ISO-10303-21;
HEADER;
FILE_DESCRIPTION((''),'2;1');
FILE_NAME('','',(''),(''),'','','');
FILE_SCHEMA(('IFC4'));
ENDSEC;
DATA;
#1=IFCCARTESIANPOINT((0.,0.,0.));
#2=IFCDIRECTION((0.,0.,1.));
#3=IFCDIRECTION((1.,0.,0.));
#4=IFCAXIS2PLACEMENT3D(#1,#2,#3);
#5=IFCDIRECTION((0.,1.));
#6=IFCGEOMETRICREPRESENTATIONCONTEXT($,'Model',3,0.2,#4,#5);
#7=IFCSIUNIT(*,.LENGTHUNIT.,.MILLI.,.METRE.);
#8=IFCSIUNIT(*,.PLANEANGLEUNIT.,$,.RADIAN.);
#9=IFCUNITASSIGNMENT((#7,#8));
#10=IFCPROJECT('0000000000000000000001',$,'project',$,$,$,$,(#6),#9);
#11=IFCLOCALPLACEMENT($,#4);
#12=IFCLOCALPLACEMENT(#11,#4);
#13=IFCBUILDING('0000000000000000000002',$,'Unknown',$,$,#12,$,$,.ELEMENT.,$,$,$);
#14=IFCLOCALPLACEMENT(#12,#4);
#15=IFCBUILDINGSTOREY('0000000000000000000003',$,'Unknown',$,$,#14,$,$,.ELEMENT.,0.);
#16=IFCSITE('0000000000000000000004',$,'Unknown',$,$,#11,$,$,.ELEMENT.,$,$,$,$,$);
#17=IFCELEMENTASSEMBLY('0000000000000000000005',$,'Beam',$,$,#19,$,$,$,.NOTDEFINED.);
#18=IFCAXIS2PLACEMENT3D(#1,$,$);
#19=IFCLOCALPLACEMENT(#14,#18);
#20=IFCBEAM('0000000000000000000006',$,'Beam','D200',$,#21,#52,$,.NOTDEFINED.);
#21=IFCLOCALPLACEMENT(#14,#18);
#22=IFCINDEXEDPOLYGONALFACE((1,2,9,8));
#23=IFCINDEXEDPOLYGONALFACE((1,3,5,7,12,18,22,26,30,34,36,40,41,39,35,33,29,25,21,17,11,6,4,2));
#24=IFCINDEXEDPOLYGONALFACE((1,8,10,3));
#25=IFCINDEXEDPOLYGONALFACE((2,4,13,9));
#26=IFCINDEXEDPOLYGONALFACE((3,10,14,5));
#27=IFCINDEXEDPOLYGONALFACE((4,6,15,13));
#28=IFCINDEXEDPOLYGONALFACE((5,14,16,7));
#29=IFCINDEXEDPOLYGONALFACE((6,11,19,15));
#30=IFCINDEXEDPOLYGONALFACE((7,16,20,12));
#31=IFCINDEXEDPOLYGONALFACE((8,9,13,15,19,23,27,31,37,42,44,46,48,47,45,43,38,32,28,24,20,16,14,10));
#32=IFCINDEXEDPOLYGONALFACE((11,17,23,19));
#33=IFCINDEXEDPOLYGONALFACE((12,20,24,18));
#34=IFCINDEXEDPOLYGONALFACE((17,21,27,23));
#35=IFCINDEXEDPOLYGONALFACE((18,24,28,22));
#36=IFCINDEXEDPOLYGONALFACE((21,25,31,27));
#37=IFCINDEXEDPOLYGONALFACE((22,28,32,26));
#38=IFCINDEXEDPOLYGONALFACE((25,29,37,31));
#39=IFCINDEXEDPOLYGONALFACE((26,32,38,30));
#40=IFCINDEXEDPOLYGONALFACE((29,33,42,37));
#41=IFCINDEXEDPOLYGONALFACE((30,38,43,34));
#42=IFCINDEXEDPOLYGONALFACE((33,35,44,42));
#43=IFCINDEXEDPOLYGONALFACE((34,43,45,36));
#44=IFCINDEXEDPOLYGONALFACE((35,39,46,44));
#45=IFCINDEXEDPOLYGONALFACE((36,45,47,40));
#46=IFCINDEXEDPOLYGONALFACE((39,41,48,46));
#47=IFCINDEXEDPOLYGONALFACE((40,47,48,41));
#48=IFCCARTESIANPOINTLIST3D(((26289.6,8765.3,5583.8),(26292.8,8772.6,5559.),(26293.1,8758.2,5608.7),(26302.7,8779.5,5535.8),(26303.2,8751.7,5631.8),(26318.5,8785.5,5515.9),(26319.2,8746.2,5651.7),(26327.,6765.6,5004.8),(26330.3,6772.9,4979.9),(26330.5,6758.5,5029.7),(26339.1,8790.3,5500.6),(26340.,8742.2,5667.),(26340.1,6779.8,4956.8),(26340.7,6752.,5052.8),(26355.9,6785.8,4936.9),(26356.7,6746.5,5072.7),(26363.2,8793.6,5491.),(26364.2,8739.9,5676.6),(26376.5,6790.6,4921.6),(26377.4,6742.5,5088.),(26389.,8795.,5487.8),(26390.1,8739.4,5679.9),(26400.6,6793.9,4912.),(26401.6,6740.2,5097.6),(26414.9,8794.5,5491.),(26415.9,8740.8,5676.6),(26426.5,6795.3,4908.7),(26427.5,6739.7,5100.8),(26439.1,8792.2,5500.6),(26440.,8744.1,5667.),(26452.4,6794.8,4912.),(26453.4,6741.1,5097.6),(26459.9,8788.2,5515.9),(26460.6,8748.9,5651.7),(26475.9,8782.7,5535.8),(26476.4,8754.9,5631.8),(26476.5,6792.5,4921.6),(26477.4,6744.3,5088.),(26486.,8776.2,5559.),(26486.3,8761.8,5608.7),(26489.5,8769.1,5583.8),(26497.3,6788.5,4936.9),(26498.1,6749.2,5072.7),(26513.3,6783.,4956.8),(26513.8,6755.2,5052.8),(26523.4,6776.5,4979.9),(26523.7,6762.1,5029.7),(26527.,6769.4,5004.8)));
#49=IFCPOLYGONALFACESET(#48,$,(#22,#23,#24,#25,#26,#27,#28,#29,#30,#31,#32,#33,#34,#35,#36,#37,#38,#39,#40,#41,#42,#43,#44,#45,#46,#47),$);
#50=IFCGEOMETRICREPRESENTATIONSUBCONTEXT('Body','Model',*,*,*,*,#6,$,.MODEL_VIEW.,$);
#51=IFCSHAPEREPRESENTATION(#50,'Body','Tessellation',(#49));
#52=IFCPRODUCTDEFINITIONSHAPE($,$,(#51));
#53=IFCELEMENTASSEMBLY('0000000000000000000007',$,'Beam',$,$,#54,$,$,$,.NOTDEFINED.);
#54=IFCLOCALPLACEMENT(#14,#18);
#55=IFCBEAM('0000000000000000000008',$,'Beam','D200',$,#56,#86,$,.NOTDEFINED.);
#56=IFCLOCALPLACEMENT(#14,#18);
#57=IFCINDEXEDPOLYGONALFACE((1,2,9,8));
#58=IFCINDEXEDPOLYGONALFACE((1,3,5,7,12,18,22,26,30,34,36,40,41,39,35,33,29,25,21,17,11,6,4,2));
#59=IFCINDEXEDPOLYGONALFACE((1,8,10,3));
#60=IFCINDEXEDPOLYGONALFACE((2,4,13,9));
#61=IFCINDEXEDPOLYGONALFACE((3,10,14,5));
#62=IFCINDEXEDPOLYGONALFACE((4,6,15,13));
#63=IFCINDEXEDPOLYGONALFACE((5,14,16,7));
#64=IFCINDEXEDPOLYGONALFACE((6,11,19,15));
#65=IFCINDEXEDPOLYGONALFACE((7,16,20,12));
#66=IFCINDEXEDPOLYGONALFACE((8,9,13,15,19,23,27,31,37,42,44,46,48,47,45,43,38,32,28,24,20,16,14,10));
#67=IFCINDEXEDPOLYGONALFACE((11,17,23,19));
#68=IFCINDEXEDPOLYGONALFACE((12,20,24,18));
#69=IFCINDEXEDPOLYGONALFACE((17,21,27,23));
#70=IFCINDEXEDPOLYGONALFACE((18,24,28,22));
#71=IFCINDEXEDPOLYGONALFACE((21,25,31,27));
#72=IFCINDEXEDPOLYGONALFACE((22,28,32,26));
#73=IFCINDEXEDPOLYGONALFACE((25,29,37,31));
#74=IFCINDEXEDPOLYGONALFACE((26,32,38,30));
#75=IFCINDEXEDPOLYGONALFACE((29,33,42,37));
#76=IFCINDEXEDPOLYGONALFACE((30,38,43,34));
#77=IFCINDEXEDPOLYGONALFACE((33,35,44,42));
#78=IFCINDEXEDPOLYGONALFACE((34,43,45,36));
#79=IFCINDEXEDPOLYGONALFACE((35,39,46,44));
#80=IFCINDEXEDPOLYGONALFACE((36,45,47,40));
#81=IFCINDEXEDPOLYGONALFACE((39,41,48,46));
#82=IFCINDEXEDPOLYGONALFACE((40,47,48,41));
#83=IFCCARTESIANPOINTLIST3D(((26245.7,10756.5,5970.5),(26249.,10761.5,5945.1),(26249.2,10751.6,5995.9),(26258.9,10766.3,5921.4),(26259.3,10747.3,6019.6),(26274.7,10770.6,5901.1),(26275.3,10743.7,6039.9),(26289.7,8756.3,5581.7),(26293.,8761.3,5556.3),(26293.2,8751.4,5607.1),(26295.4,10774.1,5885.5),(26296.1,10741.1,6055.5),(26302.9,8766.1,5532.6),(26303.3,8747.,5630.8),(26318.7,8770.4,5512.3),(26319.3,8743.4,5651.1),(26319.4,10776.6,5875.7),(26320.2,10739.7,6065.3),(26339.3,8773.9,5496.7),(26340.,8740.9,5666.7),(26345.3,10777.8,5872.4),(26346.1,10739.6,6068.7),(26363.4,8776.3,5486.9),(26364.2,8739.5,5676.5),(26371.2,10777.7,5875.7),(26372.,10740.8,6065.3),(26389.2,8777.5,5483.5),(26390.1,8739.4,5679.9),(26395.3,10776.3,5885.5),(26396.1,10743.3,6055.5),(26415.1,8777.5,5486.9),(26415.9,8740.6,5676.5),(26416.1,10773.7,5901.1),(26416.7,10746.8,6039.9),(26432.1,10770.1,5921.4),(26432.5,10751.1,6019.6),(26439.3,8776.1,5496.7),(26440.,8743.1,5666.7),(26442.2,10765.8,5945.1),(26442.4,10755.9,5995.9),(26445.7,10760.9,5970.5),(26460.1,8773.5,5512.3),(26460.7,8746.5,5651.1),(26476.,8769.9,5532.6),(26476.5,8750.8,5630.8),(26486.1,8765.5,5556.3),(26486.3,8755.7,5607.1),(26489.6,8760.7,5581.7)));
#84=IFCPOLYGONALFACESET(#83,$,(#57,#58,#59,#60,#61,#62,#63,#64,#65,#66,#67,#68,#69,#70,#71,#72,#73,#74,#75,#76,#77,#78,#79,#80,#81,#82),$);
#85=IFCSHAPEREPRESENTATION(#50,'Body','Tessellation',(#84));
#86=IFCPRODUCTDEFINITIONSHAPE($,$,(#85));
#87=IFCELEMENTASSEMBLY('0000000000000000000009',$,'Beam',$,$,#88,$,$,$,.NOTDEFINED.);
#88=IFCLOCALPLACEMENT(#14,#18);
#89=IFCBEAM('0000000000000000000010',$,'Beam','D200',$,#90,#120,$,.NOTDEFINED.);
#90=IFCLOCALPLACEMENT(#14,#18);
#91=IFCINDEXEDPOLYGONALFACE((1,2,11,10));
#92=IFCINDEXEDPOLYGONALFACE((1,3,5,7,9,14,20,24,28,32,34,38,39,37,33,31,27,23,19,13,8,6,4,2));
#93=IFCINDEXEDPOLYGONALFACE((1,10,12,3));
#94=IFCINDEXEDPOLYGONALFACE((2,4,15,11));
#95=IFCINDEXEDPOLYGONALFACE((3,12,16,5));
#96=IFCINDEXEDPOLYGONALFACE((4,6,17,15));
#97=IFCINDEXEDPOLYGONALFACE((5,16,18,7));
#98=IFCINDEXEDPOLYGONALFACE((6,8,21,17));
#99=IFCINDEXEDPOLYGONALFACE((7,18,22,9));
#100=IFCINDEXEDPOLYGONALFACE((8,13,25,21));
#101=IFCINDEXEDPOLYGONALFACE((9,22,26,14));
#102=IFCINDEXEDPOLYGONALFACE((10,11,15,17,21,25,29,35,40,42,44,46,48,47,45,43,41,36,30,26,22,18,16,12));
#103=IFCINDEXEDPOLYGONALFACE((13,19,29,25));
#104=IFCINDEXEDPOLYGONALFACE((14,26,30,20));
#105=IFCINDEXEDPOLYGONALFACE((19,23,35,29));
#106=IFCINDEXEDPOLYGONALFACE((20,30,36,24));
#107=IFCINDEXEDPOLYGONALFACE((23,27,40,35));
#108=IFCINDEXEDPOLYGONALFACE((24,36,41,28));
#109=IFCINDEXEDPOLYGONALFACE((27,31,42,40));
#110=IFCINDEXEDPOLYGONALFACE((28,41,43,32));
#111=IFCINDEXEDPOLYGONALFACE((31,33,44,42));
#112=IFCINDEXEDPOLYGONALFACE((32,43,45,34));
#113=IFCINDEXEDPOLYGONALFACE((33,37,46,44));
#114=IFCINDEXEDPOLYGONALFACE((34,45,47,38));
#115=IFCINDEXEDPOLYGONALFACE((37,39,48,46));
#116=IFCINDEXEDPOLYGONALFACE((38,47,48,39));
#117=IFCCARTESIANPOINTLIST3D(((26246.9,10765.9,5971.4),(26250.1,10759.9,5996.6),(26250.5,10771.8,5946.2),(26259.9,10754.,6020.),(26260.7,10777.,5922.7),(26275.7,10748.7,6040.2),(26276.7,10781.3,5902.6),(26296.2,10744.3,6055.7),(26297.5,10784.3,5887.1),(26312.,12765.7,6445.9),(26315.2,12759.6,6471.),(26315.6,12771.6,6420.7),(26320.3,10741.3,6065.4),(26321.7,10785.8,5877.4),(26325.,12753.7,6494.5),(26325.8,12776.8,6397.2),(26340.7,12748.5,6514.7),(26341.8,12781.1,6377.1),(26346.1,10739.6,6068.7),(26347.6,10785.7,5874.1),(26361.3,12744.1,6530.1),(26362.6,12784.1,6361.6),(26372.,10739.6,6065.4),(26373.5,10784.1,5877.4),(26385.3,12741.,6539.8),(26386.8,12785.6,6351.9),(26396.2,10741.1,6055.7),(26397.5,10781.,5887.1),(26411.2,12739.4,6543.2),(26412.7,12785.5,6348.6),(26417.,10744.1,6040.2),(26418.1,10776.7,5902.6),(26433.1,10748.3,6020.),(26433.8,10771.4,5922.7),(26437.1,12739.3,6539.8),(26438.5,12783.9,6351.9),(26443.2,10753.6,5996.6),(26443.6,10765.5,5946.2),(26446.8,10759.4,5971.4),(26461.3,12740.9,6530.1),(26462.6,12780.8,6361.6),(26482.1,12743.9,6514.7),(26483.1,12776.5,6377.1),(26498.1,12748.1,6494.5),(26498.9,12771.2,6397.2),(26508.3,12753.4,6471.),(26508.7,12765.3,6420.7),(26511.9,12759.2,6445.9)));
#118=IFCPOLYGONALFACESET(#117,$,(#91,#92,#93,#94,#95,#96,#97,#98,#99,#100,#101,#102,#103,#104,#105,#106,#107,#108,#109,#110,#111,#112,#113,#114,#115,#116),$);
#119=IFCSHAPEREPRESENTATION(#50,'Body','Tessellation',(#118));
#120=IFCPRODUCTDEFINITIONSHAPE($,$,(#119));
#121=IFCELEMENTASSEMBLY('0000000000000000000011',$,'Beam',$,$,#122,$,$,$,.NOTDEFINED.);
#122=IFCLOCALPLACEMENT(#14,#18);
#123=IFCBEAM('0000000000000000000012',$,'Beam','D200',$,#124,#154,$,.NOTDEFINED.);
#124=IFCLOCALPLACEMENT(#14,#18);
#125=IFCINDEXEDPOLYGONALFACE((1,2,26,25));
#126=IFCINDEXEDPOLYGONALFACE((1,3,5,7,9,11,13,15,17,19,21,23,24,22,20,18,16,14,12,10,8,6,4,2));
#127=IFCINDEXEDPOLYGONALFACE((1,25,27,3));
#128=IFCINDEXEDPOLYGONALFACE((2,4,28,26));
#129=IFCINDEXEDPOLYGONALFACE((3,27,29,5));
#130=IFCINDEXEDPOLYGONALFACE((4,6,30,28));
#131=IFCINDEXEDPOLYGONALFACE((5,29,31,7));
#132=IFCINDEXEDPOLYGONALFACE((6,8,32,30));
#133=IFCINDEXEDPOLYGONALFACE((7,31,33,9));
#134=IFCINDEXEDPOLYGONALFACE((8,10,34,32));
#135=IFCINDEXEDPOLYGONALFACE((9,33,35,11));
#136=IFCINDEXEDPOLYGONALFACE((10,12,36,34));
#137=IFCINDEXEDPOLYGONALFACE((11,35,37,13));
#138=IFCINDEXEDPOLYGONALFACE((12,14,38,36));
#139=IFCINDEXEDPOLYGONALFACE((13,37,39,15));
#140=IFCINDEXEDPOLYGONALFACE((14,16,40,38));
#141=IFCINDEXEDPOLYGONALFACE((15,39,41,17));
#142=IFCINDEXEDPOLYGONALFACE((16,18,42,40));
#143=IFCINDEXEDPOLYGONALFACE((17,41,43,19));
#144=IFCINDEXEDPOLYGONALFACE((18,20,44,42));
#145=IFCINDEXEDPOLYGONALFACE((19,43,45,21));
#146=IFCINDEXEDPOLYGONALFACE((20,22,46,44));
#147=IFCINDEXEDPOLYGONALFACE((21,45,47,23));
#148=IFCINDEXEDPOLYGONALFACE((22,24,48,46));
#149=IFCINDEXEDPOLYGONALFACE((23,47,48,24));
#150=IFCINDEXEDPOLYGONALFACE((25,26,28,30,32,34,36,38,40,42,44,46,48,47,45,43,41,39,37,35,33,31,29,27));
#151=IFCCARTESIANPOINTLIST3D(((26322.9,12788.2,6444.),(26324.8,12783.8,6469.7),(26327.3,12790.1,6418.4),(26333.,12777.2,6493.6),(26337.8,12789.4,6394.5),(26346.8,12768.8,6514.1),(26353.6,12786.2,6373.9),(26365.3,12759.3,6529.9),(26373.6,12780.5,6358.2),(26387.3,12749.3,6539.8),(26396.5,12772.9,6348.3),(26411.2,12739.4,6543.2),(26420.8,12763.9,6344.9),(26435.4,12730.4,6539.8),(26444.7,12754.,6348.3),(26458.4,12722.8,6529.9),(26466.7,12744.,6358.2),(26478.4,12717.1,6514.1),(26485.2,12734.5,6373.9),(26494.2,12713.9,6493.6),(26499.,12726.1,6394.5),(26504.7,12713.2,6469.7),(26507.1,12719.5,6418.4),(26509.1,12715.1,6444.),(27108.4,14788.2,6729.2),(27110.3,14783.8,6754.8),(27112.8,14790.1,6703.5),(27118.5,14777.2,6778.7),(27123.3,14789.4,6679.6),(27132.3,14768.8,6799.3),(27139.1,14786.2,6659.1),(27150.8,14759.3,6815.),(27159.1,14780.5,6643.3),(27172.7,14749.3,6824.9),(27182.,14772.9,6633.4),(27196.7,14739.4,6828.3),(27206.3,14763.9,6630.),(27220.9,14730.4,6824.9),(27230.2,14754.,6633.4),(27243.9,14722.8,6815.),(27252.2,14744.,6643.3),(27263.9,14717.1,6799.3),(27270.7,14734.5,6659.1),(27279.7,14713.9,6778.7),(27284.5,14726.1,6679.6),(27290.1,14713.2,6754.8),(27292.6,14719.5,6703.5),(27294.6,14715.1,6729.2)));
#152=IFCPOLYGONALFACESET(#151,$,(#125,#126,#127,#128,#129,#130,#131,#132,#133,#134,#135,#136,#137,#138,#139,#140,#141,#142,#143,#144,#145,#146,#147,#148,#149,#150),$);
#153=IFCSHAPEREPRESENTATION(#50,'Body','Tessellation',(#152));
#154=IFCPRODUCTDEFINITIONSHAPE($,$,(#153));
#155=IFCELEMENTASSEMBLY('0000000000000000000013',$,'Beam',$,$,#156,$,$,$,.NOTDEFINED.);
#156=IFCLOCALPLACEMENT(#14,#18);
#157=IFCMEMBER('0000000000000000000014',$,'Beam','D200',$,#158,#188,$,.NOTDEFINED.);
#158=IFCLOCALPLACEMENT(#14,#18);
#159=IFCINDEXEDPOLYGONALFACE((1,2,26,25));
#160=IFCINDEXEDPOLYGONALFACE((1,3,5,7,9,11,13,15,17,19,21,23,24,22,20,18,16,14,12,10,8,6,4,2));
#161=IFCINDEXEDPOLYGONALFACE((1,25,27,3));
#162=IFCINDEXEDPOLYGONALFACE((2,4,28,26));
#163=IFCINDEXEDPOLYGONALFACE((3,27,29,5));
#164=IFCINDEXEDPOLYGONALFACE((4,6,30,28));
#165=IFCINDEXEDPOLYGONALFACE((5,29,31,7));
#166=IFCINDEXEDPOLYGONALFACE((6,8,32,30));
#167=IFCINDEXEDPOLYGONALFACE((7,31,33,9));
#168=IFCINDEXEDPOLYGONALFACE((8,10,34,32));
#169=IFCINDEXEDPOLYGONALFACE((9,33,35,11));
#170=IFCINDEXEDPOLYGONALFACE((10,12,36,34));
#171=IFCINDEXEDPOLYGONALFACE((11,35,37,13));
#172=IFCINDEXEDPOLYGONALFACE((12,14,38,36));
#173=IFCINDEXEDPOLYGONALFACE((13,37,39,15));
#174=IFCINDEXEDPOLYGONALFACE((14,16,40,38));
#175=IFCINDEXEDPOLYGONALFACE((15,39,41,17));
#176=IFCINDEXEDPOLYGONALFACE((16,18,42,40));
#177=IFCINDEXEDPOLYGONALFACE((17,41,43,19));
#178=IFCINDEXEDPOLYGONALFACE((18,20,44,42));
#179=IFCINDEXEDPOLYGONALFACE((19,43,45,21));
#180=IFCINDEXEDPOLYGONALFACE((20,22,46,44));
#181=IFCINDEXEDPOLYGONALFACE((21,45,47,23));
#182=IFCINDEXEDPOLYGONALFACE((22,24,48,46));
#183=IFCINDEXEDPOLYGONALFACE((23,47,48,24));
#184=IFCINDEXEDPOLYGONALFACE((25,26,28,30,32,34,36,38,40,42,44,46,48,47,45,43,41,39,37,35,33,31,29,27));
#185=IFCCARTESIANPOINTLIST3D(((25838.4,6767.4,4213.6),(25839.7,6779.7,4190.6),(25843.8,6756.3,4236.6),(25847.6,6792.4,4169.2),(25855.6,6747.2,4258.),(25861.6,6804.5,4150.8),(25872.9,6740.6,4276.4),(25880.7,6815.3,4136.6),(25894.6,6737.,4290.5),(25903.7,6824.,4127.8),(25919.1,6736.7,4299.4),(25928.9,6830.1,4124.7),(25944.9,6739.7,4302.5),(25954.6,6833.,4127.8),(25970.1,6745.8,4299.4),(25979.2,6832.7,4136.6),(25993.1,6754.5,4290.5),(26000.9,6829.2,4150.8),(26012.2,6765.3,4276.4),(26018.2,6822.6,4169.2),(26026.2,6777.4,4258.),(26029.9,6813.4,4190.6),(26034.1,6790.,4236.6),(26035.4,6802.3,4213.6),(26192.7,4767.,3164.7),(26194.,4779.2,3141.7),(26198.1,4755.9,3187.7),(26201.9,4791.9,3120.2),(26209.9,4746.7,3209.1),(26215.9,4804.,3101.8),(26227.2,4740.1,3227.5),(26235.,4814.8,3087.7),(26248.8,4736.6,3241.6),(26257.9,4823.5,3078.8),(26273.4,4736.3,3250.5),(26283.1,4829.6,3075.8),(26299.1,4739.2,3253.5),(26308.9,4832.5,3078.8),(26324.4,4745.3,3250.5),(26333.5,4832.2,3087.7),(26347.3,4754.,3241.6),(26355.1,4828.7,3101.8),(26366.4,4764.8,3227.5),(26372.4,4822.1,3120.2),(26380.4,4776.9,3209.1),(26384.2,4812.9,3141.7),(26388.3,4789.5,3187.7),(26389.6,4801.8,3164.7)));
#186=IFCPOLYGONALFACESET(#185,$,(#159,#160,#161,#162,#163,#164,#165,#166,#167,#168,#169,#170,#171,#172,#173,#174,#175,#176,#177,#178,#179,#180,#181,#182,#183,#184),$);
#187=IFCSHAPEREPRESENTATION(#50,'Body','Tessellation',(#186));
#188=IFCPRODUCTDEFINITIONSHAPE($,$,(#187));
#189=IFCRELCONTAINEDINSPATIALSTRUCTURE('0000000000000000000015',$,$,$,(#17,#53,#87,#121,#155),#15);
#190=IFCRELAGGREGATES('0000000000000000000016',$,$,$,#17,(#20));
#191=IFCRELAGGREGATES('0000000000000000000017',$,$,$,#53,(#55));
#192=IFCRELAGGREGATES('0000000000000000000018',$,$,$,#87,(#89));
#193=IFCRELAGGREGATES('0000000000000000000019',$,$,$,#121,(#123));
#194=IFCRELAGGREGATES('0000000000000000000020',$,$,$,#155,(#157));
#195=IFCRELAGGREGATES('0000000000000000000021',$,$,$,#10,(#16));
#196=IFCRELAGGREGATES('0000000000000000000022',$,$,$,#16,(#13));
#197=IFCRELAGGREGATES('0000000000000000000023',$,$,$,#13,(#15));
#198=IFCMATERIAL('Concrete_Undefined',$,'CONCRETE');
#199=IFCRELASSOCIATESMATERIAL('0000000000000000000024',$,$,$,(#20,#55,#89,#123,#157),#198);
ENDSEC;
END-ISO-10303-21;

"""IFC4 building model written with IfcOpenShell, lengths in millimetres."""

from ifc_helpers import new_model, si_unit, direction, frame, origin_with_axes, place, context, subcontext, project, spatial, line, indexed_curve, outline, extrude, material, element, aggregate, save


model = new_model("IFC4")

# Units and contexts
model_context = context("Model", 3, precision=0.2, world=origin_with_axes(), true_north=direction((0.0, 1.0)))
body_context = subcontext(model_context, "Body", "Model", "MODEL_VIEW")
ifc_project = project(units=[si_unit("LENGTHUNIT", "METRE", prefix="MILLI"), si_unit("PLANEANGLEUNIT", "RADIAN")], contexts=[model_context])

# Site, building, storey
site_placement = place(None, origin_with_axes())
site = spatial("IfcSite", under=ifc_project, at=site_placement, Name="Unknown", CompositionType="ELEMENT")
building_placement = place(site_placement, origin_with_axes())
building = spatial("IfcBuilding", under=site, at=building_placement, Name="Unknown", CompositionType="ELEMENT")
storey_placement = place(building_placement, origin_with_axes())
storey = spatial("IfcBuildingStorey", under=building, at=storey_placement, Name="Unknown", CompositionType="ELEMENT", Elevation=0.0)

# Shared definitions
ifc_material = material(Name="Concrete_Undefined", Category="CONCRETE")

# Element assemblies, beams
assembly_1_placement = place(storey_placement, frame((26389.6, 8767.2, 5583.8), z_axis=(-0.999825, -0.018712, 0.0), x_axis=(0.017974, -0.960389, -0.278083)))
assembly_1 = element("IfcElementAssembly", 1, at=assembly_1_placement, inside=storey, Name="Beam", PredefinedType="NOTDEFINED")
beam_1_placement = place(assembly_1_placement, origin_with_axes())
beam_1 = element("IfcBeam", 2, at=beam_1_placement, material=ifc_material, Name="Beam", Description="D200", PredefinedType="NOTDEFINED", context=body_context, shape_type="SolidModel", body=[
    extrude(outline(indexed_curve([(100.0, 0.0), (96.6, 25.9), (86.6, 50.0), (70.7, 70.7), (50.0, 86.6), (25.9, 96.6), (0.0, 100.0), (-25.9, 96.6), (-50.0, 86.6), (-70.7, 70.7), (-86.6, 50.0), (-96.6, 25.9), (-100.0, 0.0), (-96.6, -25.9), (-86.6, -50.0), (-70.7, -70.7), (-50.0, -86.6), (-25.9, -96.6), (0.0, -100.0), (25.9, -96.6), (50.0, -86.6), (70.7, -70.7), (86.6, -50.0), (96.6, -25.9)], segments=[line(1, 2, 3, 4, 5, 6, 7, 8, 9, 10, 11, 12, 13, 14, 15, 16, 17, 18, 19, 20, 21, 22, 23, 24, 1)])), frame((0.0, 0.0, 0.0), z_axis=(-1.0, 0.0, 0.0), x_axis=(0.0, 0.0, 1.0)), (0.0, 0.0, -1.0), 2082.2),
])
aggregate(assembly_1, [beam_1])
assembly_2_placement = place(storey_placement, frame((26345.7, 10758.7, 5970.5), z_axis=(-0.999759, -0.021971, 0.0), x_axis=(0.021567, -0.981397, -0.190775)))
assembly_2 = element("IfcElementAssembly", 3, at=assembly_2_placement, inside=storey, Name="Beam", PredefinedType="NOTDEFINED")
beam_2_placement = place(assembly_2_placement, origin_with_axes())
beam_2 = element("IfcBeam", 4, at=beam_2_placement, material=ifc_material, Name="Beam", Description="D200", PredefinedType="NOTDEFINED", context=body_context, shape_type="SolidModel", body=[
    extrude(outline(indexed_curve([(100.0, 0.0), (96.6, 25.9), (86.6, 50.0), (70.7, 70.7), (50.0, 86.6), (25.9, 96.6), (0.0, 100.0), (-25.9, 96.6), (-50.0, 86.6), (-70.7, 70.7), (-86.6, 50.0), (-96.6, 25.9), (-100.0, 0.0), (-96.6, -25.9), (-86.6, -50.0), (-70.7, -70.7), (-50.0, -86.6), (-25.9, -96.6), (0.0, -100.0), (25.9, -96.6), (50.0, -86.6), (70.7, -70.7), (86.6, -50.0), (96.6, -25.9)], segments=[line(1, 2, 3, 4, 5, 6, 7, 8, 9, 10, 11, 12, 13, 14, 15, 16, 17, 18, 19, 20, 21, 22, 23, 24, 1)])), frame((0.0, 0.0, 0.0), z_axis=(-1.0, 0.0, 0.0), x_axis=(0.0, 0.0, 1.0)), (0.0, 0.0, -1.0), 2038.1),
])
aggregate(assembly_2, [beam_2])
assembly_3_placement = place(storey_placement, frame((26411.9, 12762.5, 6445.9), z_axis=(-0.999471, 0.032518, 0.0), x_axis=(-0.031641, -0.972502, -0.230735)))
assembly_3 = element("IfcElementAssembly", 5, at=assembly_3_placement, inside=storey, Name="Beam", PredefinedType="NOTDEFINED")
beam_3_placement = place(assembly_3_placement, origin_with_axes())
beam_3 = element("IfcBeam", 6, at=beam_3_placement, material=ifc_material, Name="Beam", Description="D200", PredefinedType="NOTDEFINED", context=body_context, shape_type="SolidModel", body=[
    extrude(outline(indexed_curve([(100.0, 0.0), (96.6, 25.9), (86.6, 50.0), (70.7, 70.7), (50.0, 86.6), (25.9, 96.6), (0.0, 100.0), (-25.9, 96.6), (-50.0, 86.6), (-70.7, 70.7), (-86.6, 50.0), (-96.6, 25.9), (-100.0, 0.0), (-96.6, -25.9), (-86.6, -50.0), (-70.7, -70.7), (-50.0, -86.6), (-25.9, -96.6), (0.0, -100.0), (25.9, -96.6), (50.0, -86.6), (70.7, -70.7), (86.6, -50.0), (96.6, -25.9)], segments=[line(1, 2, 3, 4, 5, 6, 7, 8, 9, 10, 11, 12, 13, 14, 15, 16, 17, 18, 19, 20, 21, 22, 23, 24, 1)])), frame((0.0, 0.0, 0.0), z_axis=(-1.0, 0.0, 0.0), x_axis=(0.0, 0.0, 1.0)), (0.0, 0.0, -1.0), 2056.3),
])
aggregate(assembly_3, [beam_3])
assembly_4_placement = place(storey_placement, frame((27201.5, 14751.6, 6729.2), z_axis=(-0.930788, 0.36556, 0.0), x_axis=(-0.362384, -0.922699, -0.131549)))
assembly_4 = element("IfcElementAssembly", 7, at=assembly_4_placement, inside=storey, Name="Beam", PredefinedType="NOTDEFINED")
beam_4_placement = place(assembly_4_placement, origin_with_axes())
beam_4 = element("IfcBeam", 8, at=beam_4_placement, material=ifc_material, Name="Beam", Description="D200", PredefinedType="NOTDEFINED", context=body_context, shape_type="SolidModel", body=[
    extrude(outline(indexed_curve([(100.0, 0.0), (96.6, 25.9), (86.6, 50.0), (70.7, 70.7), (50.0, 86.6), (25.9, 96.6), (0.0, 100.0), (-25.9, 96.6), (-50.0, 86.6), (-70.7, 70.7), (-86.6, 50.0), (-96.6, 25.9), (-100.0, 0.0), (-96.6, -25.9), (-86.6, -50.0), (-70.7, -70.7), (-50.0, -86.6), (-25.9, -96.6), (0.0, -100.0), (25.9, -96.6), (50.0, -86.6), (70.7, -70.7), (86.6, -50.0), (96.6, -25.9)], segments=[line(1, 2, 3, 4, 5, 6, 7, 8, 9, 10, 11, 12, 13, 14, 15, 16, 17, 18, 19, 20, 21, 22, 23, 24, 1)])), frame((0.0, 0.0, 0.0), z_axis=(-1.0, 0.0, 0.0), x_axis=(0.0, 0.0, 1.0)), (0.0, 0.0, -1.0), 2167.6),
])
aggregate(assembly_4, [beam_4])

# Element assembly, member
assembly_5_placement = place(storey_placement, frame((25936.9, 6784.9, 4213.6), z_axis=(-0.98468, -0.174373, 0.0), x_axis=(0.15494, -0.874943, -0.458768)))
assembly_5 = element("IfcElementAssembly", 9, at=assembly_5_placement, inside=storey, Name="Beam", PredefinedType="NOTDEFINED")
member_1_placement = place(assembly_5_placement, origin_with_axes())
member_1 = element("IfcMember", 10, at=member_1_placement, material=ifc_material, Name="Beam", Description="D200", PredefinedType="NOTDEFINED", context=body_context, shape_type="SolidModel", body=[
    extrude(outline(indexed_curve([(100.0, 0.0), (96.6, 25.9), (86.6, 50.0), (70.7, 70.7), (50.0, 86.6), (25.9, 96.6), (0.0, 100.0), (-25.9, 96.6), (-50.0, 86.6), (-70.7, 70.7), (-86.6, 50.0), (-96.6, 25.9), (-100.0, 0.0), (-96.6, -25.9), (-86.6, -50.0), (-70.7, -70.7), (-50.0, -86.6), (-25.9, -96.6), (0.0, -100.0), (25.9, -96.6), (50.0, -86.6), (70.7, -70.7), (86.6, -50.0), (96.6, -25.9)], segments=[line(1, 2, 3, 4, 5, 6, 7, 8, 9, 10, 11, 12, 13, 14, 15, 16, 17, 18, 19, 20, 21, 22, 23, 24, 1)])), frame((0.0, 0.0, 0.0), z_axis=(-1.0, 0.0, 0.0), x_axis=(0.0, 0.0, 1.0)), (0.0, 0.0, -1.0), 2286.4),
])
aggregate(assembly_5, [member_1])

save(model, "model.ifc")
